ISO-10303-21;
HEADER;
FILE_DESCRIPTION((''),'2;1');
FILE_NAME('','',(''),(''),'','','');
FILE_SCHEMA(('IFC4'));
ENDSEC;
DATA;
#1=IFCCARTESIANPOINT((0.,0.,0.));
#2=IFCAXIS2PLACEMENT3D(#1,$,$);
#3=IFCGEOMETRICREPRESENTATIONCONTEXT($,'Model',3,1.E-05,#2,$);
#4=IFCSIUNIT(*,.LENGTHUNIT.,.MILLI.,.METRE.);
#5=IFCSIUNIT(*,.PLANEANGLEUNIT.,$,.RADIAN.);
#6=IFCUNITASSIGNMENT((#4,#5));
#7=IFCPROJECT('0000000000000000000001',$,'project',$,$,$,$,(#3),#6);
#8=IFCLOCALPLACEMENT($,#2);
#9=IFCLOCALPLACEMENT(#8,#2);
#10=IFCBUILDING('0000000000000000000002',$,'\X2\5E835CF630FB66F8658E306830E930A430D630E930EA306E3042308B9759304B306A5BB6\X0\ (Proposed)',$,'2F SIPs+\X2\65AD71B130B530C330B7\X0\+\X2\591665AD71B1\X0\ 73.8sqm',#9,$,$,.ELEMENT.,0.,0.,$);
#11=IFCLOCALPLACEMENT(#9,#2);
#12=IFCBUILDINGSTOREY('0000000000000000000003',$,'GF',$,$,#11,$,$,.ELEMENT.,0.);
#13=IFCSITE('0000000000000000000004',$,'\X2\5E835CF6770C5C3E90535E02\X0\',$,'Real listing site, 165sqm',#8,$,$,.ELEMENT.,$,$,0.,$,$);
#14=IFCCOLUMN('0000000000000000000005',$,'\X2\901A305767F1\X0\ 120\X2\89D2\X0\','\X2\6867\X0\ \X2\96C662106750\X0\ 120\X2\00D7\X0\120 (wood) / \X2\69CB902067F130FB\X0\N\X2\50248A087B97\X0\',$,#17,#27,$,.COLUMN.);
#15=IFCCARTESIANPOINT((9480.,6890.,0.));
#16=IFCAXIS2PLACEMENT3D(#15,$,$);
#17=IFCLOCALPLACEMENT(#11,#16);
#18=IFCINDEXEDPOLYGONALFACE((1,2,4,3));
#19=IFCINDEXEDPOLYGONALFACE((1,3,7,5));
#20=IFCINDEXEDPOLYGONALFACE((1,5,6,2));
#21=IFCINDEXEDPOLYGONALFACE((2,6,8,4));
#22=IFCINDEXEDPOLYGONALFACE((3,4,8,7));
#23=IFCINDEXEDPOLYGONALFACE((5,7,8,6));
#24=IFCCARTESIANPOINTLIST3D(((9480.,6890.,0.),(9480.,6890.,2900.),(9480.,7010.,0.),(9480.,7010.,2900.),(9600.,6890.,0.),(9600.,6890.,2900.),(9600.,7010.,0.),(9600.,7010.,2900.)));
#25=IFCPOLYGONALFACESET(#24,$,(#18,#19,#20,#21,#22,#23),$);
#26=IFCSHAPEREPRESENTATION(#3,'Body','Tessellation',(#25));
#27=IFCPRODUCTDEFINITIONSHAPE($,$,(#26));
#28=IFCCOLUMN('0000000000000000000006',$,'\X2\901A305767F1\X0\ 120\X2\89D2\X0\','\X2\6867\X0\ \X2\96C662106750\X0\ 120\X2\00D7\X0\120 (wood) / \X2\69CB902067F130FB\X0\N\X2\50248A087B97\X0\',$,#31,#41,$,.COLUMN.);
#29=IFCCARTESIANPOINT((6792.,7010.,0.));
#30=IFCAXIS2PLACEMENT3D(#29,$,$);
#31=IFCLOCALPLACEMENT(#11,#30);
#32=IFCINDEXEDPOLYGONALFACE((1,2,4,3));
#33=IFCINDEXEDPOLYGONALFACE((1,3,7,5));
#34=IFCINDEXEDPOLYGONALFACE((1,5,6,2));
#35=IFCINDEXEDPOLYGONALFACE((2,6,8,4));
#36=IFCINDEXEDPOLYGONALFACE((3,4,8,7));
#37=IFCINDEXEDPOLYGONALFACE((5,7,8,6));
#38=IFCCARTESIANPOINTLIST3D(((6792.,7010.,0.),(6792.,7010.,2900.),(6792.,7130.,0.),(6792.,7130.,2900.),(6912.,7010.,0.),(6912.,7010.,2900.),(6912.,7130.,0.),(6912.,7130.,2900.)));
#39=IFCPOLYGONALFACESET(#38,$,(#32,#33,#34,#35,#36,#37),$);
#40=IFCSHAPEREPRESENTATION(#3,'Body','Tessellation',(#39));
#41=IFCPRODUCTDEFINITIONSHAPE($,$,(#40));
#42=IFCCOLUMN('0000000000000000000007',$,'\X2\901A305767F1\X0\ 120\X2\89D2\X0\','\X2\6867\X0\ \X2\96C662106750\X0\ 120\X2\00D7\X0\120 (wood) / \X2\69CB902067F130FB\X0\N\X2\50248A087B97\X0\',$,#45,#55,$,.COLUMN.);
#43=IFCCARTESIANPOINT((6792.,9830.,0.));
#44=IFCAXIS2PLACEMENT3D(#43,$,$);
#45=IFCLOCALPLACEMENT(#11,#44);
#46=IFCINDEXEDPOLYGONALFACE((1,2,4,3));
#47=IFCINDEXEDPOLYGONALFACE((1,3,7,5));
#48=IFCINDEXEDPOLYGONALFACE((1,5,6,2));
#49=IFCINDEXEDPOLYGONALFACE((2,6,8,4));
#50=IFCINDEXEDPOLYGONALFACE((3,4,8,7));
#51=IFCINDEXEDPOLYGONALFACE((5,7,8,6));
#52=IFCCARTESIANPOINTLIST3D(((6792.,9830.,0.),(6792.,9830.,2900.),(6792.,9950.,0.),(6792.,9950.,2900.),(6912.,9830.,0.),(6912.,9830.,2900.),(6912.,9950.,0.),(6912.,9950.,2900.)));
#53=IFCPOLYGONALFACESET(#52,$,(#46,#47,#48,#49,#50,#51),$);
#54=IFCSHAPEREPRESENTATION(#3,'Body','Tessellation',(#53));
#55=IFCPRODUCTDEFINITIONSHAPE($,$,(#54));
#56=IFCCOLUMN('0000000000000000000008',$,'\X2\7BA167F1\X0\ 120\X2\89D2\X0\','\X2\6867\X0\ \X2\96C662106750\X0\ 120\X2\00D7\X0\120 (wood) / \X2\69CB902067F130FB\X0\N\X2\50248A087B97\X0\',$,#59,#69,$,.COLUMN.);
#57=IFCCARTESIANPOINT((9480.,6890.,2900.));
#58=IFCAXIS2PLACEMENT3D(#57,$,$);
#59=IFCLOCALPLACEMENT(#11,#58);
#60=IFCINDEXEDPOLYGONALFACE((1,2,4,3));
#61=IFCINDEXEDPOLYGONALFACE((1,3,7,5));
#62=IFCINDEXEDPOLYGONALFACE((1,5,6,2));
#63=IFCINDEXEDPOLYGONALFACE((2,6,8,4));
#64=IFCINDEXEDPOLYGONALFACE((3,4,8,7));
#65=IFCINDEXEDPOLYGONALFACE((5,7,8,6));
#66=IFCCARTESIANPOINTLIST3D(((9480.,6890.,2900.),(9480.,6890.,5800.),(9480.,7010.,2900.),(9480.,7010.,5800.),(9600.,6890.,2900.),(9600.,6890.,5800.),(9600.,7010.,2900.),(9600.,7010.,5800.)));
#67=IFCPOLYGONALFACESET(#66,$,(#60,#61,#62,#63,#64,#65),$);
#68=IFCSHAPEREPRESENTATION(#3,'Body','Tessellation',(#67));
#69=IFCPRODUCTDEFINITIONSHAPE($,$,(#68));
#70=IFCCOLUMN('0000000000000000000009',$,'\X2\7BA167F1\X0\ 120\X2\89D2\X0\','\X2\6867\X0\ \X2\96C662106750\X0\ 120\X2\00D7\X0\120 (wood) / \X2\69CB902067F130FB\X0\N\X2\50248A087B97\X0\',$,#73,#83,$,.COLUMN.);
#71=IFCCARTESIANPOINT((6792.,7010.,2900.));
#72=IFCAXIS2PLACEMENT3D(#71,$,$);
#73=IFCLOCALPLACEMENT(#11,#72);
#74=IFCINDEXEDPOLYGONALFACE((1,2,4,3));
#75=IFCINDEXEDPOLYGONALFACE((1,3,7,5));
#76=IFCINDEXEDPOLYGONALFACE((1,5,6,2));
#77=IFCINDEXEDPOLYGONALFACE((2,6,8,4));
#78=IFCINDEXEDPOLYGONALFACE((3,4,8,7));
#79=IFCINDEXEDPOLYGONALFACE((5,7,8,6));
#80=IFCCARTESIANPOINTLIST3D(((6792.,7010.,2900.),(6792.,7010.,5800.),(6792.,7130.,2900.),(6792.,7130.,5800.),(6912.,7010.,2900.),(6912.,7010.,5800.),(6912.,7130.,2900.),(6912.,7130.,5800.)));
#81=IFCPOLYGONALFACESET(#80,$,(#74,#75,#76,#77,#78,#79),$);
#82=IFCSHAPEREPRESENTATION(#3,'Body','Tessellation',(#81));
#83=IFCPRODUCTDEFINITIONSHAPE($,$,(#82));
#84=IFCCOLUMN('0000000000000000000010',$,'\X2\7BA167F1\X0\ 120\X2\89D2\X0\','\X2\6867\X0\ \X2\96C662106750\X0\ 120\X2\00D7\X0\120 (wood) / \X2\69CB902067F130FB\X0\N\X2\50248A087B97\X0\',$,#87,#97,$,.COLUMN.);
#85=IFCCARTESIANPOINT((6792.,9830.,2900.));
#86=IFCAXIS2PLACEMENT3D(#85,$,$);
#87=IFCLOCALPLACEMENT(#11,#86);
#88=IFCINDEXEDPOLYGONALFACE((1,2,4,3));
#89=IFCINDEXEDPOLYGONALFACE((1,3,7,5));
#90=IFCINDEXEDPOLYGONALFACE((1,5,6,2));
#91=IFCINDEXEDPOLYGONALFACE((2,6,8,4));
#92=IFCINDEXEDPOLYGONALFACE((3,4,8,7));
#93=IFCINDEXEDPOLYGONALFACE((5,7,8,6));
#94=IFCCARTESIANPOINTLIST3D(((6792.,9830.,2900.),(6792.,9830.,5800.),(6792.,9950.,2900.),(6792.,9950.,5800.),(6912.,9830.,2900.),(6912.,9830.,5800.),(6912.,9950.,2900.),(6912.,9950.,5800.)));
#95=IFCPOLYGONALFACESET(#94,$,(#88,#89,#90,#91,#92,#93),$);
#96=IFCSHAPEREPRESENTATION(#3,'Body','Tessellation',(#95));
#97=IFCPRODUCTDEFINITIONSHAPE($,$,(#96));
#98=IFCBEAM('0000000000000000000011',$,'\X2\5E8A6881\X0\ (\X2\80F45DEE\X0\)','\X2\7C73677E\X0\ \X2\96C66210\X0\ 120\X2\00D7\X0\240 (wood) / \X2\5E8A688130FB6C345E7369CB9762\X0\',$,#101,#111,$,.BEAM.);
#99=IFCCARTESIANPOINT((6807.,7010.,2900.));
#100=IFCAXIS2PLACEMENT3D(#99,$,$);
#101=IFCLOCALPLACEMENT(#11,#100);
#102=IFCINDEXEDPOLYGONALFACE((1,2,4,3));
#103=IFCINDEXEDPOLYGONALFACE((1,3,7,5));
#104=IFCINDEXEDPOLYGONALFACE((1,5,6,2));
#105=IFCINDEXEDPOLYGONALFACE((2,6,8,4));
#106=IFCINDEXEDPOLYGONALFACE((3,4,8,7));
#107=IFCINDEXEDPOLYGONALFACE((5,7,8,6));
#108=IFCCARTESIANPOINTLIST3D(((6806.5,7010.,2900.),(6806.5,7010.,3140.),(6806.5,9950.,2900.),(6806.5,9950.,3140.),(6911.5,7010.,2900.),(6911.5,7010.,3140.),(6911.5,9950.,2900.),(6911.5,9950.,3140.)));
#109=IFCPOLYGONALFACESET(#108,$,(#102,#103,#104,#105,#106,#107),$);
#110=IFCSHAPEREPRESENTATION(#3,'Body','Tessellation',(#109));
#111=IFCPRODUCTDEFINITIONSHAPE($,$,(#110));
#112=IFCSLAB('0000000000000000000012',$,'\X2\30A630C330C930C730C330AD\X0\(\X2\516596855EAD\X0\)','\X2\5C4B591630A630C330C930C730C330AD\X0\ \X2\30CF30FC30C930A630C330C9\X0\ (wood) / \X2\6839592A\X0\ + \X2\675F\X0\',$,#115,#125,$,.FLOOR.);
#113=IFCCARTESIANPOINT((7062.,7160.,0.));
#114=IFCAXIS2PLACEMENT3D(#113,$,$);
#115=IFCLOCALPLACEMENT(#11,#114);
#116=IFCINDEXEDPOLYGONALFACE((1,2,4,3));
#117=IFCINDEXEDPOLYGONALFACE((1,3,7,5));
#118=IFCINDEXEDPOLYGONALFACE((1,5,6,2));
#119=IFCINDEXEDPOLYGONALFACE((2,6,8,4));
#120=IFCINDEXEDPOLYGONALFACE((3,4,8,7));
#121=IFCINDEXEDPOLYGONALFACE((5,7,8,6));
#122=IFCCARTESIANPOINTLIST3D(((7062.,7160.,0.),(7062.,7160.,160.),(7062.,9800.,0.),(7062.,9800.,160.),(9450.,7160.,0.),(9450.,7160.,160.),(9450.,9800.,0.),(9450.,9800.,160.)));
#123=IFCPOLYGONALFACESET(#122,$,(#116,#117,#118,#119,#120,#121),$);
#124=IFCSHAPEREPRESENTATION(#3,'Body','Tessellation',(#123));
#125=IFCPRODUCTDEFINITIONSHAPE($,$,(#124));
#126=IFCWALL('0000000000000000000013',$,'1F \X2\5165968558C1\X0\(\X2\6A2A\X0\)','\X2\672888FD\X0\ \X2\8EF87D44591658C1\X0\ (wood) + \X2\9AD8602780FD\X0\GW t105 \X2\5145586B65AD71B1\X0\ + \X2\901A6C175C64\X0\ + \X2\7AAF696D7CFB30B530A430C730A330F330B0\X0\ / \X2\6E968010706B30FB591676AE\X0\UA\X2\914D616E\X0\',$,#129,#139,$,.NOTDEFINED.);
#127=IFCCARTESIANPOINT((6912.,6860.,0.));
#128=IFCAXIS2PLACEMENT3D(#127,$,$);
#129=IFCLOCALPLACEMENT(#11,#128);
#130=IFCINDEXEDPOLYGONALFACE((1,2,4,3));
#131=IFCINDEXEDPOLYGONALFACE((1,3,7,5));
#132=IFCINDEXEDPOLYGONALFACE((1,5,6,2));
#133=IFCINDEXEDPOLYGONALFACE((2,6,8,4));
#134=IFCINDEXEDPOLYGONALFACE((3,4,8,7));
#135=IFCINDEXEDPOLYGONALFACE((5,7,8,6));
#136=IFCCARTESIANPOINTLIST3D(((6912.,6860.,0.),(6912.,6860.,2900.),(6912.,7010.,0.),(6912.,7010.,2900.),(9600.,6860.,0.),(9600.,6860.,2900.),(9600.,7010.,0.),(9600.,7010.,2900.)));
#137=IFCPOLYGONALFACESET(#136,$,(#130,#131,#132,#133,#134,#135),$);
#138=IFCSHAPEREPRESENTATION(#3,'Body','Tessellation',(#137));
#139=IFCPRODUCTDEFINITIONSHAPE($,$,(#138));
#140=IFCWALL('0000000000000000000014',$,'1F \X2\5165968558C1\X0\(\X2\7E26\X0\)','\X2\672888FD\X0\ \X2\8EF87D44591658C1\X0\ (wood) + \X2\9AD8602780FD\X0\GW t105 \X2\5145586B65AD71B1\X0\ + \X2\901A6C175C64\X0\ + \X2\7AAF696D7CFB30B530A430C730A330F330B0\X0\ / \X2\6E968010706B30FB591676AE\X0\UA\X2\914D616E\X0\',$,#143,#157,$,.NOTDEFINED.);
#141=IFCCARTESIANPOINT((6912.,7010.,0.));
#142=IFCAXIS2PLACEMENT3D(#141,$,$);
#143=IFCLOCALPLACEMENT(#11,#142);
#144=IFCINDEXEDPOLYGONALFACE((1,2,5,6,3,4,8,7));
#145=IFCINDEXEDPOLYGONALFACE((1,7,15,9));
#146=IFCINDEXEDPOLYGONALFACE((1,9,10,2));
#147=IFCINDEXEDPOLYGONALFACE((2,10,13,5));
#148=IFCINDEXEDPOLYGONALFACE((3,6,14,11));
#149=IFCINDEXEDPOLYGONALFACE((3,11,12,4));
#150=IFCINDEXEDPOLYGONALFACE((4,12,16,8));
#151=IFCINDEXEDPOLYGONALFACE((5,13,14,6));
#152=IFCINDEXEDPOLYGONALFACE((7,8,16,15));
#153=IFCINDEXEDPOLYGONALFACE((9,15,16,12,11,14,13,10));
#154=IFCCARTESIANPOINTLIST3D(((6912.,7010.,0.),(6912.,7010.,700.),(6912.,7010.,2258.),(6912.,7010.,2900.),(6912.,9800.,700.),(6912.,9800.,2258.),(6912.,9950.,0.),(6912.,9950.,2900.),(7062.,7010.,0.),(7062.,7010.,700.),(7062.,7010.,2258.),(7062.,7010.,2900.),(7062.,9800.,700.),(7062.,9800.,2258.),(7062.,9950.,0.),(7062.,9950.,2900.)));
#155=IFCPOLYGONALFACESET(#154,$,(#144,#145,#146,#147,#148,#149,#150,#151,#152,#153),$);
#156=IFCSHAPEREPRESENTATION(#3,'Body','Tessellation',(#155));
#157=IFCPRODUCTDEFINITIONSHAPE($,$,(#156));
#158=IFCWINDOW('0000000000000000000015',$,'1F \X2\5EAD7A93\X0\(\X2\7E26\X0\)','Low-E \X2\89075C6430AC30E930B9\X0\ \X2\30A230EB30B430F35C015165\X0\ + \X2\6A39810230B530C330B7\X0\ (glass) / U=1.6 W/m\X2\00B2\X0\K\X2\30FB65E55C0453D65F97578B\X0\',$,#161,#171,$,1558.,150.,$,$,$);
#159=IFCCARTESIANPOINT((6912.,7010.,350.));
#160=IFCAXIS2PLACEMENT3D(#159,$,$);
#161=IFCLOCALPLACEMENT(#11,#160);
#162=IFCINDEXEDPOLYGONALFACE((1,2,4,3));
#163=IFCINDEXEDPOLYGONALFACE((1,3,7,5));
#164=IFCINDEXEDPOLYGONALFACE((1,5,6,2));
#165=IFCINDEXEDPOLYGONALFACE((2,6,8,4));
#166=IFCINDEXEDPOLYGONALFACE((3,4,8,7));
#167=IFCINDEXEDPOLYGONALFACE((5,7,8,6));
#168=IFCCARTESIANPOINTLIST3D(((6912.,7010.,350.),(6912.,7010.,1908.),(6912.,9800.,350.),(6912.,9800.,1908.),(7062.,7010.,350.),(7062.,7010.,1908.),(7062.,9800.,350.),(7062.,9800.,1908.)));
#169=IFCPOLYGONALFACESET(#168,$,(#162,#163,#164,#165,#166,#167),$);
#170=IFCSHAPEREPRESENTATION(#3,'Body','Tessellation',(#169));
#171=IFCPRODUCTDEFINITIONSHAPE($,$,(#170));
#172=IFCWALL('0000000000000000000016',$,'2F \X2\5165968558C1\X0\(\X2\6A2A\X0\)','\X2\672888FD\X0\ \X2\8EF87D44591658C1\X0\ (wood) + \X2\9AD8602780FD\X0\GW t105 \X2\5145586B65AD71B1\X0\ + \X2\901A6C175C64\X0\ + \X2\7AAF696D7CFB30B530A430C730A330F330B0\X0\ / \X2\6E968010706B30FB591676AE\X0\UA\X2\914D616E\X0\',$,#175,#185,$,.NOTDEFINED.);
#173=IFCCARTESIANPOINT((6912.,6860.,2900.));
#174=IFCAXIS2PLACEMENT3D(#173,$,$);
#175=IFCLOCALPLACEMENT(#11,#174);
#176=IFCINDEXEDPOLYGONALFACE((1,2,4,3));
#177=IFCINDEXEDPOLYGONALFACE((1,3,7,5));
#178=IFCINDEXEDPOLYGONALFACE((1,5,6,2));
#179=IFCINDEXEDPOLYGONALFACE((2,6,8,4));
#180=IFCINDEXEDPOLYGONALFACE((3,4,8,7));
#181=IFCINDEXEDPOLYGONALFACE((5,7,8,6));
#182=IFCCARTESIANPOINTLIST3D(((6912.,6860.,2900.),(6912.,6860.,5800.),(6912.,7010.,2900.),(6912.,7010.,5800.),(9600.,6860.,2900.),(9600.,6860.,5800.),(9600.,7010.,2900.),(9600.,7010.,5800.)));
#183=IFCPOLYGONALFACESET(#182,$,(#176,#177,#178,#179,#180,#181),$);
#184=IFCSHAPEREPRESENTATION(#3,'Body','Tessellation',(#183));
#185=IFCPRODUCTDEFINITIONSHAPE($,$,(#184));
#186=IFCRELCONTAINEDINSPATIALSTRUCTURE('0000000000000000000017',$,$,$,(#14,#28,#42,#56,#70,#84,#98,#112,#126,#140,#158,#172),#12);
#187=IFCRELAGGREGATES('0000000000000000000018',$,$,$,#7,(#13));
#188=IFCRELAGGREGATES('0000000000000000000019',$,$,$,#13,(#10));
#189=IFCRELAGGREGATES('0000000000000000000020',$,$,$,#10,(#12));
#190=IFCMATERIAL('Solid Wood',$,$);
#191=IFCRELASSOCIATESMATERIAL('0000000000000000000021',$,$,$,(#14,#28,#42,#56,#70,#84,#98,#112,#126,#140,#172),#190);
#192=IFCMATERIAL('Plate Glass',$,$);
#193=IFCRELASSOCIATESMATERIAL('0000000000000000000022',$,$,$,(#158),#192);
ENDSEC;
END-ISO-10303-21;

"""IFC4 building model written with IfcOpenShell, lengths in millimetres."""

from ifc_helpers import new_model, si_unit, frame, frame_2d, origin, place, context, project, spatial, rectangle, extrude, material, element, fill, save


model = new_model("IFC4")

# Units and contexts
model_context = context("Model", 3, precision=1e-05, world=origin())
ifc_project = project(units=[si_unit("LENGTHUNIT", "METRE", prefix="MILLI"), si_unit("PLANEANGLEUNIT", "RADIAN")], contexts=[model_context])

# Site, building, storey
site_placement = place(None, origin())
site = spatial("IfcSite", under=ifc_project, at=site_placement, Name="広島県尾道市", ObjectType="Real listing site, 165sqm", CompositionType="ELEMENT", RefElevation=0.0)
building_placement = place(site_placement, origin())
building = spatial("IfcBuilding", under=site, at=building_placement, Name="広島・書斎とライブラリのある静かな家 (Proposed)", ObjectType="2F SIPs+断熱サッシ+外断熱 73.8sqm", CompositionType="ELEMENT", ElevationOfRefHeight=0.0, ElevationOfTerrain=0.0)
storey_placement = place(building_placement, origin())
storey = spatial("IfcBuildingStorey", under=building, at=storey_placement, Name="GF", CompositionType="ELEMENT", Elevation=0.0)

# Columns
ifc_material_1 = material(Name="Solid Wood")
column_1_placement = place(storey_placement, frame((9480.0, 6890.0, 0.0)))
element("IfcColumn", 1, at=column_1_placement, inside=storey, material=ifc_material_1, Name="通し柱 120角", Description="桧 集成材 120×120 (wood) / 構造柱・N値計算", PredefinedType="COLUMN", context=model_context, shape_type="SweptSolid", body=[
    extrude(rectangle(XDim=120.0, YDim=120.0, at=frame_2d((60.0, 60.0))), frame((9480.0, 6890.0, 0.0)), (0.0, 0.0, 1.0), 2900.0),
])
column_2_placement = place(storey_placement, frame((6792.0, 7010.0, 0.0)))
element("IfcColumn", 2, at=column_2_placement, inside=storey, material=ifc_material_1, Name="通し柱 120角", Description="桧 集成材 120×120 (wood) / 構造柱・N値計算", PredefinedType="COLUMN", context=model_context, shape_type="SweptSolid", body=[
    extrude(rectangle(XDim=120.0, YDim=120.0, at=frame_2d((60.0, 60.0))), frame((6792.0, 7010.0, 0.0)), (0.0, 0.0, 1.0), 2900.0),
])
column_3_placement = place(storey_placement, frame((6792.0, 9830.0, 0.0)))
element("IfcColumn", 3, at=column_3_placement, inside=storey, material=ifc_material_1, Name="通し柱 120角", Description="桧 集成材 120×120 (wood) / 構造柱・N値計算", PredefinedType="COLUMN", context=model_context, shape_type="SweptSolid", body=[
    extrude(rectangle(XDim=120.0, YDim=120.0, at=frame_2d((60.0, 60.0))), frame((6792.0, 9830.0, 0.0)), (0.0, 0.0, 1.0), 2900.0),
])
column_4_placement = place(storey_placement, frame((9480.0, 6890.0, 2900.0)))
element("IfcColumn", 4, at=column_4_placement, inside=storey, material=ifc_material_1, Name="管柱 120角", Description="桧 集成材 120×120 (wood) / 構造柱・N値計算", PredefinedType="COLUMN", context=model_context, shape_type="SweptSolid", body=[
    extrude(rectangle(XDim=120.0, YDim=120.0, at=frame_2d((60.0, 60.0))), frame((9480.0, 6890.0, 2900.0)), (0.0, 0.0, 1.0), 2900.0),
])
column_5_placement = place(storey_placement, frame((6792.0, 7010.0, 2900.0)))
element("IfcColumn", 5, at=column_5_placement, inside=storey, material=ifc_material_1, Name="管柱 120角", Description="桧 集成材 120×120 (wood) / 構造柱・N値計算", PredefinedType="COLUMN", context=model_context, shape_type="SweptSolid", body=[
    extrude(rectangle(XDim=120.0, YDim=120.0, at=frame_2d((60.0, 60.0))), frame((6792.0, 7010.0, 2900.0)), (0.0, 0.0, 1.0), 2900.0),
])
column_6_placement = place(storey_placement, frame((6792.0, 9830.0, 2900.0)))
element("IfcColumn", 6, at=column_6_placement, inside=storey, material=ifc_material_1, Name="管柱 120角", Description="桧 集成材 120×120 (wood) / 構造柱・N値計算", PredefinedType="COLUMN", context=model_context, shape_type="SweptSolid", body=[
    extrude(rectangle(XDim=120.0, YDim=120.0, at=frame_2d((60.0, 60.0))), frame((6792.0, 9830.0, 2900.0)), (0.0, 0.0, 1.0), 2900.0),
])

# Beam
beam_1_placement = place(storey_placement, frame((6807.0, 7010.0, 2900.0)))
element("IfcBeam", 7, at=beam_1_placement, inside=storey, material=ifc_material_1, Name="床梁 (胴差)", Description="米松 集成 120×240 (wood) / 床梁・水平構面", PredefinedType="BEAM", context=model_context, shape_type="SweptSolid", body=[
    extrude(rectangle(XDim=105.0, YDim=2940.0, at=frame_2d((52.0, 1470.0))), frame((6807.0, 7010.0, 2900.0)), (0.0, 0.0, 1.0), 240.0),
])

# Slab
slab_placement = place(storey_placement, frame((7062.0, 7160.0, 0.0)))
element("IfcSlab", 8, at=slab_placement, inside=storey, material=ifc_material_1, Name="ウッドデッキ(入隅庭)", Description="屋外ウッドデッキ ハードウッド (wood) / 根太 + 束", PredefinedType="FLOOR", context=model_context, shape_type="SweptSolid", body=[
    extrude(rectangle(XDim=2388.0, YDim=2640.0, at=frame_2d((1194.0, 1320.0))), frame((7062.0, 7160.0, 0.0)), (0.0, 0.0, 1.0), 160.0),
])

# Wall
wall_1_placement = place(storey_placement, frame((6912.0, 6860.0, 0.0)))
element("IfcWall", 9, at=wall_1_placement, inside=storey, material=ifc_material_1, Name="1F 入隅壁(横)", Description="木製 軸組外壁 (wood) + 高性能GW t105 充填断熱 + 通気層 + 窯業系サイディング / 準耐火・外皮UA配慮", PredefinedType="NOTDEFINED", context=model_context, shape_type="SweptSolid", body=[
    extrude(rectangle(XDim=2688.0, YDim=150.0, at=frame_2d((1344.0, 75.0))), frame((6912.0, 6860.0, 0.0)), (0.0, 0.0, 1.0), 2900.0),
])

# Wall, opening, window
wall_2_placement = place(storey_placement, frame((6912.0, 7010.0, 0.0)))
wall_2 = element("IfcWall", 10, at=wall_2_placement, inside=storey, material=ifc_material_1, Name="1F 入隅壁(縦)", Description="木製 軸組外壁 (wood) + 高性能GW t105 充填断熱 + 通気層 + 窯業系サイディング / 準耐火・外皮UA配慮", PredefinedType="NOTDEFINED", context=model_context, shape_type="SweptSolid", body=[
    extrude(rectangle(XDim=150.0, YDim=2940.0, at=frame_2d((75.0, 1470.0))), frame((6912.0, 7010.0, 0.0)), (0.0, 0.0, 1.0), 2900.0),
])
opening_1_placement = place(storey_placement, frame((6912.0, 7010.0, 350.0)))
opening_1 = element("IfcOpeningElement", 11, at=opening_1_placement, cuts=wall_2, PredefinedType="NOTDEFINED", context=model_context, shape_type="SweptSolid", body=[
    extrude(rectangle(XDim=150.0, YDim=2790.0, at=frame_2d((75.0, 1395.0))), frame((6912.0, 7010.0, 350.0)), (0.0, 0.0, 1.0), 1558.0),
])
ifc_material_2 = material(Name="Plate Glass")
window_1_placement = place(storey_placement, frame((6912.0, 7010.0, 350.0)))
window_1 = element("IfcWindow", 12, at=window_1_placement, inside=storey, material=ifc_material_2, Name="1F 庭窓(縦)", Description="Low-E 複層ガラス アルゴン封入 + 樹脂サッシ (glass) / U=1.6 W/m²K・日射取得型", OverallHeight=1558.0, OverallWidth=150.0, context=model_context, shape_type="SweptSolid", body=[
    extrude(rectangle(XDim=150.0, YDim=2790.0, at=frame_2d((75.0, 1395.0))), frame((6912.0, 7010.0, 350.0)), (0.0, 0.0, 1.0), 1558.0),
])
fill(opening_1, window_1)

# Wall
wall_3_placement = place(storey_placement, frame((6912.0, 6860.0, 2900.0)))
element("IfcWall", 13, at=wall_3_placement, inside=storey, material=ifc_material_1, Name="2F 入隅壁(横)", Description="木製 軸組外壁 (wood) + 高性能GW t105 充填断熱 + 通気層 + 窯業系サイディング / 準耐火・外皮UA配慮", PredefinedType="NOTDEFINED", context=model_context, shape_type="SweptSolid", body=[
    extrude(rectangle(XDim=2688.0, YDim=150.0, at=frame_2d((1344.0, 75.0))), frame((6912.0, 6860.0, 2900.0)), (0.0, 0.0, 1.0), 2900.0),
])

save(model, "model.ifc")
